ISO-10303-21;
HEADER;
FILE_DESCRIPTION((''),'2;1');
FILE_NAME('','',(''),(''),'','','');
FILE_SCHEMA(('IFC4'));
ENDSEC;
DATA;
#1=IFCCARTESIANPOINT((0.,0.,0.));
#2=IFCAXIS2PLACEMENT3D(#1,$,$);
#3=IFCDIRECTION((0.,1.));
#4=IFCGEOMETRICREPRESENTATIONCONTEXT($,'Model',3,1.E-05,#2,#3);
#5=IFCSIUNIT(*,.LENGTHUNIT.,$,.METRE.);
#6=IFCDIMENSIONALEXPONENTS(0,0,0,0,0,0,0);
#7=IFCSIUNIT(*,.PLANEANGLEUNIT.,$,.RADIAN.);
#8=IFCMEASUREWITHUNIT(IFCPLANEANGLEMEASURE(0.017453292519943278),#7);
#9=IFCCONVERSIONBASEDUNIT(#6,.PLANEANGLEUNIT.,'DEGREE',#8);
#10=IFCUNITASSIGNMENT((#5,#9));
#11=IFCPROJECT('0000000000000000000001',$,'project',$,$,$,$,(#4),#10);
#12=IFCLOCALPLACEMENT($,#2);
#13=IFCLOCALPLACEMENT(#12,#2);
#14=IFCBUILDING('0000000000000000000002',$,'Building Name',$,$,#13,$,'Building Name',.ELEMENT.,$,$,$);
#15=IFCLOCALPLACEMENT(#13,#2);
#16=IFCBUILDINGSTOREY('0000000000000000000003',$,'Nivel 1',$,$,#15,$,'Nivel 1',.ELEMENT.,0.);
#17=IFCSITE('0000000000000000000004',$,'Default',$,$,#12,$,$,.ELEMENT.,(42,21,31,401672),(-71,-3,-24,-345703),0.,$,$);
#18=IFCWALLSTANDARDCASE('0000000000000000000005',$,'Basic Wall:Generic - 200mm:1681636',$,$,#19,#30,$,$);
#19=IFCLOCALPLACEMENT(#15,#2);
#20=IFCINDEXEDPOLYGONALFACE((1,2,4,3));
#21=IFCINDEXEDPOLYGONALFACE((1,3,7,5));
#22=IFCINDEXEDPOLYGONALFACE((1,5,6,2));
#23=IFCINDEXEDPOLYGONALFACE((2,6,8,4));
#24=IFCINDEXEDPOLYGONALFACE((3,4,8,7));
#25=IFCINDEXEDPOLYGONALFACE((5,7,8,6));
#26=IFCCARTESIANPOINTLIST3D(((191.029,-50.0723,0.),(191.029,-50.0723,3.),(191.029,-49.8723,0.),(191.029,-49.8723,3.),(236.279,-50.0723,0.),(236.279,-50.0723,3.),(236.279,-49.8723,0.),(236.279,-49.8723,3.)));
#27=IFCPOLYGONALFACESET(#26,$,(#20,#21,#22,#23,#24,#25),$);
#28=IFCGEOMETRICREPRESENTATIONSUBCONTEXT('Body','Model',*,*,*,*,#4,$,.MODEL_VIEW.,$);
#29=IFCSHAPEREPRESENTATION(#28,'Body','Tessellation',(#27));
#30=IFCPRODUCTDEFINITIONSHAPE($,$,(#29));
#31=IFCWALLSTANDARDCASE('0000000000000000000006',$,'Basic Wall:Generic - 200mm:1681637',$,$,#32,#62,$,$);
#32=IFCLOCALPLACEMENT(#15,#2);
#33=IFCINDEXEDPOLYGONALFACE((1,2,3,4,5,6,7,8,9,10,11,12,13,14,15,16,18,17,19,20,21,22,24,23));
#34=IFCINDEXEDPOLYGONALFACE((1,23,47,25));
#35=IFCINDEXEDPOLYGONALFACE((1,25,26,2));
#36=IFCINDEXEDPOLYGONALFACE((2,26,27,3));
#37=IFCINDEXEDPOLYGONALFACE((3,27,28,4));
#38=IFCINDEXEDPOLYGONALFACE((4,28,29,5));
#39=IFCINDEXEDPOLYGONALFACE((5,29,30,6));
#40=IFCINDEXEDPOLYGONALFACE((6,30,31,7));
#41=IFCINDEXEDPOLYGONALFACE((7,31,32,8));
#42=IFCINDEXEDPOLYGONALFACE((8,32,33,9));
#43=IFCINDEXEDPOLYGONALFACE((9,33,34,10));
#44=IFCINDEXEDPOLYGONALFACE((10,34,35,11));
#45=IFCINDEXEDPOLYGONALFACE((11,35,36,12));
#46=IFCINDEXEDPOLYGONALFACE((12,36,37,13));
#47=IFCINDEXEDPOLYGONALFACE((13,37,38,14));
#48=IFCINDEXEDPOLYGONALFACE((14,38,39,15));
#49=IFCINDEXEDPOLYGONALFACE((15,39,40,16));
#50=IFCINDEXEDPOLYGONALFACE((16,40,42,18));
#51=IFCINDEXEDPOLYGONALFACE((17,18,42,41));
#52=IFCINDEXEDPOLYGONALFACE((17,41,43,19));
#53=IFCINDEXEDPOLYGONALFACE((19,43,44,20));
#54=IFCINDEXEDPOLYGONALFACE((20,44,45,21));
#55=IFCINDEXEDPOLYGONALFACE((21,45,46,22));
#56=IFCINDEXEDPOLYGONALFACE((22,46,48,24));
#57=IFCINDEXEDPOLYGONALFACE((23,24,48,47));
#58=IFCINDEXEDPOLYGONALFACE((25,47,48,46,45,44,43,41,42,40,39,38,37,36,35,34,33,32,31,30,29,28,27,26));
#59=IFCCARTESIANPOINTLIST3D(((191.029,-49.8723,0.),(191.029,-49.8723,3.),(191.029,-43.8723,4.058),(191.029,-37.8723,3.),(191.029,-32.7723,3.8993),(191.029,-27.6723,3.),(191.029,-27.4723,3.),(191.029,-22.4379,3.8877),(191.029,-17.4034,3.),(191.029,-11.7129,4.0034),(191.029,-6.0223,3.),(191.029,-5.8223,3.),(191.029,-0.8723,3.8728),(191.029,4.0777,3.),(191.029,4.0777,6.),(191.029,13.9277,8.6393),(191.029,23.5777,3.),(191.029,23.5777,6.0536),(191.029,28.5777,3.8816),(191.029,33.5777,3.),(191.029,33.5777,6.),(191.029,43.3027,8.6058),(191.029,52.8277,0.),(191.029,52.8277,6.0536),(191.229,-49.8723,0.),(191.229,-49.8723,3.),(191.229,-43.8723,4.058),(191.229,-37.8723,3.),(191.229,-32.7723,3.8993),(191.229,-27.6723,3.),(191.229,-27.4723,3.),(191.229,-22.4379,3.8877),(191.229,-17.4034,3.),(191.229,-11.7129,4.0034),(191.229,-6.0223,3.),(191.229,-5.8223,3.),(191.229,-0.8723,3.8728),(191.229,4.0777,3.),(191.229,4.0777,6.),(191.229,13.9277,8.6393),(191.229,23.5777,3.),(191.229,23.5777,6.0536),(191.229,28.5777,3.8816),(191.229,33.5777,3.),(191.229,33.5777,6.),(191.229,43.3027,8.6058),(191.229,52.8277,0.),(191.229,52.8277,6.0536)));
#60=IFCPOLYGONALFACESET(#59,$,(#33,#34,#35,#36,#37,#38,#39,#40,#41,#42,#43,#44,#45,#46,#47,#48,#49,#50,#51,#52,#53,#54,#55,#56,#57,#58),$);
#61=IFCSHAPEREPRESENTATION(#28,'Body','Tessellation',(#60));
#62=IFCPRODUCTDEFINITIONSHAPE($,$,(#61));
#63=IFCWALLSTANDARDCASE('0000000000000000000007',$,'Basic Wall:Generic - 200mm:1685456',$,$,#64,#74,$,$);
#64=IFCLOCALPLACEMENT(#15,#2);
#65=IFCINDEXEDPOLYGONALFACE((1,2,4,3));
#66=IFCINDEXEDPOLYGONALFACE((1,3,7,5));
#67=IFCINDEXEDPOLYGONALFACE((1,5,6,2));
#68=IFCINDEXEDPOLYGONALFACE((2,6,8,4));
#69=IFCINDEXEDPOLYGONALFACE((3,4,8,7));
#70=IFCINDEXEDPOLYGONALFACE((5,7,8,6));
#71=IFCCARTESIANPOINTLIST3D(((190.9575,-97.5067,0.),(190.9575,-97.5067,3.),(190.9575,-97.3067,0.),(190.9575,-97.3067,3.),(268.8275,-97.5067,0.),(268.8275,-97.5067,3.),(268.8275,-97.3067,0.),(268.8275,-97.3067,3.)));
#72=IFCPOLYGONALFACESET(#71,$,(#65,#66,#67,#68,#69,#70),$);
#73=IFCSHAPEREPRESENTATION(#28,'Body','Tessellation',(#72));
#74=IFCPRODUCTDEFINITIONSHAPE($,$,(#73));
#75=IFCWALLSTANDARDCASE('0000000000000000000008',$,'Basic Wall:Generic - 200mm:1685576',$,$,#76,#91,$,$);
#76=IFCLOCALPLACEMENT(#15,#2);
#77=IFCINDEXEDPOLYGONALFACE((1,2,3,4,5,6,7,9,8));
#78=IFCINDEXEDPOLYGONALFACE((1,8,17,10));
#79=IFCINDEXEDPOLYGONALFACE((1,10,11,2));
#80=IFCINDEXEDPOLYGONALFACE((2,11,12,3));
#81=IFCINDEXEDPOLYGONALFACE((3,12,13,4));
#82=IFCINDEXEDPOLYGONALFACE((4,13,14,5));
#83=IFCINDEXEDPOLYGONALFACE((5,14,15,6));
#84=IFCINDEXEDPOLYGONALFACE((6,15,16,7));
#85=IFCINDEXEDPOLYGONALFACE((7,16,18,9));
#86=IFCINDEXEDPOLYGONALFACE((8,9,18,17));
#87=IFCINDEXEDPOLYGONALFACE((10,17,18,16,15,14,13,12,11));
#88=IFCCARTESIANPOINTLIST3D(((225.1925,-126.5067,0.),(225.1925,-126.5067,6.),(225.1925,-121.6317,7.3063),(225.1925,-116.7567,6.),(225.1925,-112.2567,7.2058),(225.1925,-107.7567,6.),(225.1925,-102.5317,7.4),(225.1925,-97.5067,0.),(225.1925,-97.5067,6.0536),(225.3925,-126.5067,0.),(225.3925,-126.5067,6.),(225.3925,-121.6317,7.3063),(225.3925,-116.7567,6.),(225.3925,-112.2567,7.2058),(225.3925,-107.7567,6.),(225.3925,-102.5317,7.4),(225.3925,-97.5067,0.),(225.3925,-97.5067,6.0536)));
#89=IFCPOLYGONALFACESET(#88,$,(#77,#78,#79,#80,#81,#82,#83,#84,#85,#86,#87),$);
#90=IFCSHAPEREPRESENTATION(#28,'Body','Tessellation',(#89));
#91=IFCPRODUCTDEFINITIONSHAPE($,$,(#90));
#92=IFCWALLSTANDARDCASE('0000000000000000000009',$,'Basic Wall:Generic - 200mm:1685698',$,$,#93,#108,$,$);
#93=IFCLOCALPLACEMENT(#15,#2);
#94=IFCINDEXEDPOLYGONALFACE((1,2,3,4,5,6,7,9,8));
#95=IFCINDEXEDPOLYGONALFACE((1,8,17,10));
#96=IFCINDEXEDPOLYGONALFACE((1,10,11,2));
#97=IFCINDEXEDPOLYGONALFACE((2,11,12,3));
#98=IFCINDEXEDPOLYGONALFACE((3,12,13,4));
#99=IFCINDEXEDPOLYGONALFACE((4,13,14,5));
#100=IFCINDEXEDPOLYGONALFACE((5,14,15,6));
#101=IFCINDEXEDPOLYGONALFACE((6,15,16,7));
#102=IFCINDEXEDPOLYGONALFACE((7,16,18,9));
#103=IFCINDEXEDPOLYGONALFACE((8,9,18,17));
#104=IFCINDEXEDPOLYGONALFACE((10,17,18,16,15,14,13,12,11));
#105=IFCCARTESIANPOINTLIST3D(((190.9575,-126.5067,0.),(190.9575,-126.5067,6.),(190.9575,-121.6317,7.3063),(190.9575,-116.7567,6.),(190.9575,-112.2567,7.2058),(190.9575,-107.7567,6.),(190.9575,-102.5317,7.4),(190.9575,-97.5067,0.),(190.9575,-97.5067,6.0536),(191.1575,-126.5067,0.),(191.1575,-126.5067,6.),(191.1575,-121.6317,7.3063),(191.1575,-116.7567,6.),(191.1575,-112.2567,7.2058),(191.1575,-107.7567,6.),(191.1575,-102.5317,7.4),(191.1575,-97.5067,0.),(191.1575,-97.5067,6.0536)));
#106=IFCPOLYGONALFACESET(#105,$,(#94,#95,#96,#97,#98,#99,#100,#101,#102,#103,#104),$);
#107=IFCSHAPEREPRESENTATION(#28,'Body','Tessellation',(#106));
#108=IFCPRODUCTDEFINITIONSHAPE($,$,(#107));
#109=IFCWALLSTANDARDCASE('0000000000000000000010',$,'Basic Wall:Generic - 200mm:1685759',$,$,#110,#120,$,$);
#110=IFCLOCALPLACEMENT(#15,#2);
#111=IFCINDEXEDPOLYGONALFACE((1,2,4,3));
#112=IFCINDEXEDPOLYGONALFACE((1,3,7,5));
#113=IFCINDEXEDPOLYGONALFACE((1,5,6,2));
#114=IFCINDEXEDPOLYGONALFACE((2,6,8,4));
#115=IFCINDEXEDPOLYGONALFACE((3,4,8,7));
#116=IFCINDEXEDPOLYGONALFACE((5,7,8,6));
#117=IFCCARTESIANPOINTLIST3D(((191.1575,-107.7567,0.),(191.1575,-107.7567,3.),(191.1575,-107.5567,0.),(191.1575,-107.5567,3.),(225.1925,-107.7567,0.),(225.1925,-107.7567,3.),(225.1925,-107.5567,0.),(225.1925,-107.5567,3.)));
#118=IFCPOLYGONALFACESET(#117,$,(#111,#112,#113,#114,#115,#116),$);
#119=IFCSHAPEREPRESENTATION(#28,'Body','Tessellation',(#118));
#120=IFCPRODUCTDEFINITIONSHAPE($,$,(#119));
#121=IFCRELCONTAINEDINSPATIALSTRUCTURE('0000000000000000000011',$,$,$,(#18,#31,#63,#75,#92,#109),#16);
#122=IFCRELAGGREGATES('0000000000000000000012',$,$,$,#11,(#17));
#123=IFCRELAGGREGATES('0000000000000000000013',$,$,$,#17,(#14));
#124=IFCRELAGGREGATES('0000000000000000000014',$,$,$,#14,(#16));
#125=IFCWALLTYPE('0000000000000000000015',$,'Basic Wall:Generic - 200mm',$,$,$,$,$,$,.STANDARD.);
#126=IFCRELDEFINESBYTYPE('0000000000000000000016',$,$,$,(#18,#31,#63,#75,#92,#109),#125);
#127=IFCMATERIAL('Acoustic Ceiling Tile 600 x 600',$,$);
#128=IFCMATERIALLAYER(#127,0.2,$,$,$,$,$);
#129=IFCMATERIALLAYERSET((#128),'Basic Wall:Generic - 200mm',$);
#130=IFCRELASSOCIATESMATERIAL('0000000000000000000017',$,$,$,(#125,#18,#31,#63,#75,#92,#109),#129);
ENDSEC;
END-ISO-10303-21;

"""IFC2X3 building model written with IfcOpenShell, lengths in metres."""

from ifc_helpers import new_model, entity, si_unit, converted_unit, direction, frame, frame_2d, origin, place, context, subcontext, project, spatial, polyline, rectangle, extrude, clip, bounded_halfspace, material, layer, layer_set, layer_usage, type_object, element, save


model = new_model("IFC2X3")

# Units and contexts
model_context = context("Model", 3, precision=1e-05, world=origin(), true_north=direction((0.0, 1.0)))
body_context = subcontext(model_context, "Body", "Model", "MODEL_VIEW")
ifc_project = project(units=[si_unit("LENGTHUNIT", "METRE"), converted_unit("PLANEANGLEUNIT", "DEGREE", entity("IfcPlaneAngleMeasure", 0.017453292519943278), si_unit("PLANEANGLEUNIT", "RADIAN"), dimensions=[0, 0, 0, 0, 0, 0, 0])], contexts=[model_context])

# Site, building, storey
site_placement = place(None, origin())
site = spatial("IfcSite", under=ifc_project, at=site_placement, Name="Default", CompositionType="ELEMENT", RefLatitude=(42, 21, 31, 401672), RefLongitude=(-71, -3, -24, -345703), RefElevation=0.0)
building_placement = place(site_placement, origin())
building = spatial("IfcBuilding", under=site, at=building_placement, Name="Building Name", LongName="Building Name", CompositionType="ELEMENT")
storey_placement = place(building_placement, origin())
storey = spatial("IfcBuildingStorey", under=building, at=storey_placement, Name="Nivel 1", LongName="Nivel 1", CompositionType="ELEMENT", Elevation=0.0)

# Walls
ifc_material_1 = material(Name="Acoustic Ceiling Tile 600 x 600")
ifc_layer = layer(ifc_material_1, 0.2)
ifc_layer_set = layer_set([ifc_layer], Name="Basic Wall:Generic - 200mm")
ifc_layer_usage_1 = layer_usage(ifc_layer_set, "AXIS2", "NEGATIVE", 0.1)
wall_type_1 = type_object("IfcWallType", Name="Basic Wall:Generic - 200mm", PredefinedType="STANDARD", material=ifc_layer_set)
wall_1_placement = place(storey_placement, frame((236.279, -49.9723, 0.0), z_axis=(0.0, 0.0, 1.0), x_axis=(-1.0, 0.0, 0.0)))
element("IfcWallStandardCase", 1, at=wall_1_placement, inside=storey, type_object=wall_type_1, material=ifc_layer_usage_1, Name="Basic Wall:Generic - 200mm:1681636", context=body_context, shape_type="SweptSolid", body=[
    extrude(rectangle(XDim=45.25, YDim=0.2, at=frame_2d((22.625, 0.0), x_axis=(-1.0, 0.0))), origin(), (0.0, 0.0, 1.0), 3.0),
])
ifc_layer_usage_2 = layer_usage(ifc_layer_set, "AXIS2", "NEGATIVE", 0.1)
wall_2_placement = place(storey_placement, frame((191.129, -49.8723, 0.0), z_axis=(0.0, 0.0, 1.0), x_axis=(0.0, 1.0, 0.0)))
solid_1 = clip(clip(clip(clip(clip(clip(clip(clip(extrude(rectangle(XDim=102.7, YDim=0.2, at=frame_2d((51.35, 0.0), x_axis=(-1.0, 0.0))), origin(), (0.0, 0.0, 1.0), 8.6393), bounded_halfspace(frame((6.0, -0.1, 4.058), z_axis=(0.173648, 0.0, 0.984808), x_axis=(0.0, 1.0, 0.0)), False, frame((6.0, -0.1, 4.058)), polyline([(0.0, 0.0), (6.0, 0.0), (6.0, 0.2), (0.0, 0.2), (0.0, 0.0)]))), bounded_halfspace(frame((17.1, -0.1, 3.8993), z_axis=(0.173648, 0.0, 0.984808), x_axis=(0.0, 1.0, 0.0)), False, frame((17.1, -0.1, 3.8993)), polyline([(0.0, 0.0), (5.1, 0.0), (5.1, 0.2), (0.0, 0.2), (0.0, 0.0)]))), bounded_halfspace(frame((27.4345, -0.1, 3.8877), z_axis=(0.173648, 0.0, 0.984808), x_axis=(0.0, 1.0, 0.0)), False, frame((27.4345, -0.1, 3.8877)), polyline([(0.0, 0.0), (5.0345, 0.0), (5.0345, 0.2), (0.0, 0.2), (0.0, 0.0)]))), bounded_halfspace(frame((38.1595, -0.1, 4.0034), z_axis=(0.173648, 0.0, 0.984808), x_axis=(0.0, 1.0, 0.0)), False, frame((38.1595, -0.1, 4.0034)), polyline([(0.0, 0.0), (5.6905, 0.0), (5.6905, 0.2), (0.0, 0.2), (0.0, 0.0)]))), bounded_halfspace(frame((49.0, -0.1, 3.8728), z_axis=(0.173648, 0.0, 0.984808), x_axis=(0.0, 1.0, 0.0)), False, frame((49.0, -0.1, 3.8728)), polyline([(0.0, 0.0), (4.95, 0.0), (4.95, 0.2), (0.0, 0.2), (0.0, 0.0)]))), bounded_halfspace(frame((93.175, -0.1, 8.6058), z_axis=(0.258819, 0.0, 0.965926), x_axis=(0.0, 1.0, 0.0)), False, frame((93.175, -0.1, 8.6058)), polyline([(0.0, 0.0), (9.525, 0.0), (9.525, 0.2), (0.0, 0.2), (0.0, 0.0)]))), bounded_halfspace(frame((78.45, -0.1, 3.8816), z_axis=(0.173648, 0.0, 0.984808), x_axis=(0.0, 1.0, 0.0)), False, frame((78.45, -0.1, 3.8816)), polyline([(0.0, 0.0), (5.0, 0.0), (5.0, 0.2), (0.0, 0.2), (0.0, 0.0)]))), bounded_halfspace(frame((63.8, -0.1, 8.6393), z_axis=(0.258819, 0.0, 0.965926), x_axis=(0.0, 1.0, 0.0)), False, frame((63.8, -0.1, 8.6393)), polyline([(0.0, 0.0), (9.65, 0.0), (9.65, 0.2), (0.0, 0.2), (0.0, 0.0)])))
solid_2 = clip(clip(clip(clip(clip(clip(clip(clip(solid_1, bounded_halfspace(frame((0.0, -0.1, 3.0), z_axis=(-0.173648, 0.0, 0.984808), x_axis=(0.0, -1.0, 0.0)), False, frame((0.0, -0.1, 3.0)), polyline([(0.0, 0.0), (6.0, 0.0), (6.0, 0.2), (0.0, 0.2), (0.0, 0.0)]))), bounded_halfspace(frame((12.0, -0.1, 3.0), z_axis=(-0.173648, 0.0, 0.984808), x_axis=(0.0, -1.0, 0.0)), False, frame((12.0, -0.1, 3.0)), polyline([(0.0, 0.0), (5.1, 0.0), (5.1, 0.2), (0.0, 0.2), (0.0, 0.0)]))), bounded_halfspace(frame((22.4, -0.1, 3.0), z_axis=(-0.173648, 0.0, 0.984808), x_axis=(0.0, -1.0, 0.0)), False, frame((22.4, -0.1, 3.0)), polyline([(0.0, 0.0), (5.0345, 0.0), (5.0345, 0.2), (0.0, 0.2), (0.0, 0.0)]))), bounded_halfspace(frame((32.469, -0.1, 3.0), z_axis=(-0.173648, 0.0, 0.984808), x_axis=(0.0, -1.0, 0.0)), False, frame((32.469, -0.1, 3.0)), polyline([(0.0, 0.0), (5.6905, 0.0), (5.6905, 0.2), (0.0, 0.2), (0.0, 0.0)]))), bounded_halfspace(frame((44.05, -0.1, 3.0), z_axis=(-0.173648, 0.0, 0.984808), x_axis=(0.0, -1.0, 0.0)), False, frame((44.05, -0.1, 3.0)), polyline([(0.0, 0.0), (4.95, 0.0), (4.95, 0.2), (0.0, 0.2), (0.0, 0.0)]))), bounded_halfspace(frame((83.45, -0.1, 6.0), z_axis=(-0.258819, 0.0, 0.965926), x_axis=(0.0, -1.0, 0.0)), False, frame((83.45, -0.1, 6.0)), polyline([(0.0, 0.0), (9.725, 0.0), (9.725, 0.2), (0.0, 0.2), (0.0, 0.0)]))), bounded_halfspace(frame((73.45, -0.1, 3.0), z_axis=(-0.173648, 0.0, 0.984808), x_axis=(0.0, -1.0, 0.0)), False, frame((73.45, -0.1, 3.0)), polyline([(0.0, 0.0), (5.0, 0.0), (5.0, 0.2), (0.0, 0.2), (0.0, 0.0)]))), bounded_halfspace(frame((53.95, -0.1, 6.0), z_axis=(-0.258819, 0.0, 0.965926), x_axis=(0.0, -1.0, 0.0)), False, frame((53.95, -0.1, 6.0)), polyline([(0.0, 0.0), (9.85, 0.0), (9.85, 0.2), (0.0, 0.2), (0.0, 0.0)])))
element("IfcWallStandardCase", 2, at=wall_2_placement, inside=storey, type_object=wall_type_1, material=ifc_layer_usage_2, Name="Basic Wall:Generic - 200mm:1681637", context=body_context, shape_type="Clipping", body=[
    clip(clip(solid_2, bounded_halfspace(frame((22.2, -0.1, 3.0), z_axis=(0.0, 0.0, 1.0), x_axis=(0.0, 1.0, 0.0)), False, frame((22.2, -0.1, 3.0)), polyline([(0.0, 0.0), (0.2, 0.0), (0.2, 0.2), (0.0, 0.2), (0.0, 0.0)]))), bounded_halfspace(frame((43.85, -0.1, 3.0), z_axis=(0.0, 0.0, 1.0), x_axis=(0.0, 1.0, 0.0)), False, frame((43.85, -0.1, 3.0)), polyline([(0.0, 0.0), (0.2, 0.0), (0.2, 0.2), (0.0, 0.2), (0.0, 0.0)]))),
])
ifc_layer_usage_3 = layer_usage(ifc_layer_set, "AXIS2", "NEGATIVE", 0.1)
wall_3_placement = place(storey_placement, frame((190.9575, -97.4067, 0.0)))
element("IfcWallStandardCase", 3, at=wall_3_placement, inside=storey, type_object=wall_type_1, material=ifc_layer_usage_3, Name="Basic Wall:Generic - 200mm:1685456", context=body_context, shape_type="SweptSolid", body=[
    extrude(rectangle(XDim=77.87, YDim=0.2, at=frame_2d((38.935, 0.0), x_axis=(-1.0, 0.0))), origin(), (0.0, 0.0, 1.0), 3.0),
])
ifc_layer_usage_4 = layer_usage(ifc_layer_set, "AXIS2", "NEGATIVE", 0.1)
wall_4_placement = place(storey_placement, frame((225.2925, -97.5067, 0.0), z_axis=(0.0, 0.0, 1.0), x_axis=(0.0, -1.0, 0.0)))
element("IfcWallStandardCase", 4, at=wall_4_placement, inside=storey, type_object=wall_type_1, material=ifc_layer_usage_4, Name="Basic Wall:Generic - 200mm:1685576", context=body_context, shape_type="Clipping", body=[
    clip(clip(clip(clip(clip(clip(extrude(rectangle(XDim=29.0, YDim=0.2, at=frame_2d((14.5, 0.0), x_axis=(-1.0, 0.0))), origin(), (0.0, 0.0, 1.0), 7.4), bounded_halfspace(frame((0.0, -0.1, 6.0536), z_axis=(-0.258819, 0.0, 0.965926), x_axis=(0.0, -1.0, 0.0)), False, frame((0.0, -0.1, 6.0536)), polyline([(0.0, 0.0), (5.025, 0.0), (5.025, 0.2), (0.0, 0.2), (0.0, 0.0)]))), bounded_halfspace(frame((10.25, -0.1, 6.0), z_axis=(-0.258819, 0.0, 0.965926), x_axis=(0.0, -1.0, 0.0)), False, frame((10.25, -0.1, 6.0)), polyline([(0.0, 0.0), (4.5, 0.0), (4.5, 0.2), (0.0, 0.2), (0.0, 0.0)]))), bounded_halfspace(frame((19.25, -0.1, 6.0), z_axis=(-0.258819, 0.0, 0.965926), x_axis=(0.0, -1.0, 0.0)), False, frame((19.25, -0.1, 6.0)), polyline([(0.0, 0.0), (4.875, 0.0), (4.875, 0.2), (0.0, 0.2), (0.0, 0.0)]))), bounded_halfspace(frame((5.025, -0.1, 7.4), z_axis=(0.258819, 0.0, 0.965926), x_axis=(0.0, 1.0, 0.0)), False, frame((5.025, -0.1, 7.4)), polyline([(0.0, 0.0), (5.225, 0.0), (5.225, 0.2), (0.0, 0.2), (0.0, 0.0)]))), bounded_halfspace(frame((14.75, -0.1, 7.2058), z_axis=(0.258819, 0.0, 0.965926), x_axis=(0.0, 1.0, 0.0)), False, frame((14.75, -0.1, 7.2058)), polyline([(0.0, 0.0), (4.5, 0.0), (4.5, 0.2), (0.0, 0.2), (0.0, 0.0)]))), bounded_halfspace(frame((24.125, -0.1, 7.3063), z_axis=(0.258819, 0.0, 0.965926), x_axis=(0.0, 1.0, 0.0)), False, frame((24.125, -0.1, 7.3063)), polyline([(0.0, 0.0), (4.675, 0.0), (4.875, 0.0), (4.875, 0.2), (0.0, 0.2), (0.0, 0.0)]))),
])
ifc_layer_usage_5 = layer_usage(ifc_layer_set, "AXIS2", "NEGATIVE", 0.1)
wall_5_placement = place(storey_placement, frame((191.0575, -126.5067, 0.0), z_axis=(0.0, 0.0, 1.0), x_axis=(0.0, 1.0, 0.0)))
element("IfcWallStandardCase", 5, at=wall_5_placement, inside=storey, type_object=wall_type_1, material=ifc_layer_usage_5, Name="Basic Wall:Generic - 200mm:1685698", context=body_context, shape_type="Clipping", body=[
    clip(clip(clip(clip(clip(clip(extrude(rectangle(XDim=29.0, YDim=0.2, at=frame_2d((14.5, 0.0), x_axis=(-1.0, 0.0))), origin(), (0.0, 0.0, 1.0), 7.4), bounded_halfspace(frame((23.975, -0.1, 7.4), z_axis=(0.258819, 0.0, 0.965926), x_axis=(0.0, 1.0, 0.0)), False, frame((23.975, -0.1, 7.4)), polyline([(0.0, 0.0), (5.025, 0.0), (5.025, 0.2), (0.0, 0.2), (0.0, 0.0)]))), bounded_halfspace(frame((14.25, -0.1, 7.2058), z_axis=(0.258819, 0.0, 0.965926), x_axis=(0.0, 1.0, 0.0)), False, frame((14.25, -0.1, 7.2058)), polyline([(0.0, 0.0), (4.5, 0.0), (4.5, 0.2), (0.0, 0.2), (0.0, 0.0)]))), bounded_halfspace(frame((4.875, -0.1, 7.3063), z_axis=(0.258819, 0.0, 0.965926), x_axis=(0.0, 1.0, 0.0)), False, frame((4.875, -0.1, 7.3063)), polyline([(0.0, 0.0), (4.875, 0.0), (4.875, 0.2), (0.0, 0.2), (0.0, 0.0)]))), bounded_halfspace(frame((18.75, -0.1, 6.0), z_axis=(-0.258819, 0.0, 0.965926), x_axis=(0.0, -1.0, 0.0)), False, frame((18.75, -0.1, 6.0)), polyline([(0.0, 0.0), (5.225, 0.0), (5.225, 0.2), (0.0, 0.2), (0.0, 0.0)]))), bounded_halfspace(frame((9.75, -0.1, 6.0), z_axis=(-0.258819, 0.0, 0.965926), x_axis=(0.0, -1.0, 0.0)), False, frame((9.75, -0.1, 6.0)), polyline([(0.0, 0.0), (4.5, 0.0), (4.5, 0.2), (0.0, 0.2), (0.0, 0.0)]))), bounded_halfspace(frame((0.0, -0.1, 6.0), z_axis=(-0.258819, 0.0, 0.965926), x_axis=(0.0, -1.0, 0.0)), False, frame((0.0, -0.1, 6.0)), polyline([(0.0, 0.0), (0.2, 0.0), (4.875, 0.0), (4.875, 0.2), (0.0, 0.2), (0.0, 0.0)]))),
])
ifc_layer_usage_6 = layer_usage(ifc_layer_set, "AXIS2", "NEGATIVE", 0.1)
wall_6_placement = place(storey_placement, frame((225.1925, -107.6567, 0.0), z_axis=(0.0, 0.0, 1.0), x_axis=(-1.0, 0.0, 0.0)))
element("IfcWallStandardCase", 6, at=wall_6_placement, inside=storey, type_object=wall_type_1, material=ifc_layer_usage_6, Name="Basic Wall:Generic - 200mm:1685759", context=body_context, shape_type="SweptSolid", body=[
    extrude(rectangle(XDim=34.035, YDim=0.2, at=frame_2d((17.0175, 0.0), x_axis=(-1.0, 0.0))), origin(), (0.0, 0.0, 1.0), 3.0),
])

save(model, "model.ifc")
